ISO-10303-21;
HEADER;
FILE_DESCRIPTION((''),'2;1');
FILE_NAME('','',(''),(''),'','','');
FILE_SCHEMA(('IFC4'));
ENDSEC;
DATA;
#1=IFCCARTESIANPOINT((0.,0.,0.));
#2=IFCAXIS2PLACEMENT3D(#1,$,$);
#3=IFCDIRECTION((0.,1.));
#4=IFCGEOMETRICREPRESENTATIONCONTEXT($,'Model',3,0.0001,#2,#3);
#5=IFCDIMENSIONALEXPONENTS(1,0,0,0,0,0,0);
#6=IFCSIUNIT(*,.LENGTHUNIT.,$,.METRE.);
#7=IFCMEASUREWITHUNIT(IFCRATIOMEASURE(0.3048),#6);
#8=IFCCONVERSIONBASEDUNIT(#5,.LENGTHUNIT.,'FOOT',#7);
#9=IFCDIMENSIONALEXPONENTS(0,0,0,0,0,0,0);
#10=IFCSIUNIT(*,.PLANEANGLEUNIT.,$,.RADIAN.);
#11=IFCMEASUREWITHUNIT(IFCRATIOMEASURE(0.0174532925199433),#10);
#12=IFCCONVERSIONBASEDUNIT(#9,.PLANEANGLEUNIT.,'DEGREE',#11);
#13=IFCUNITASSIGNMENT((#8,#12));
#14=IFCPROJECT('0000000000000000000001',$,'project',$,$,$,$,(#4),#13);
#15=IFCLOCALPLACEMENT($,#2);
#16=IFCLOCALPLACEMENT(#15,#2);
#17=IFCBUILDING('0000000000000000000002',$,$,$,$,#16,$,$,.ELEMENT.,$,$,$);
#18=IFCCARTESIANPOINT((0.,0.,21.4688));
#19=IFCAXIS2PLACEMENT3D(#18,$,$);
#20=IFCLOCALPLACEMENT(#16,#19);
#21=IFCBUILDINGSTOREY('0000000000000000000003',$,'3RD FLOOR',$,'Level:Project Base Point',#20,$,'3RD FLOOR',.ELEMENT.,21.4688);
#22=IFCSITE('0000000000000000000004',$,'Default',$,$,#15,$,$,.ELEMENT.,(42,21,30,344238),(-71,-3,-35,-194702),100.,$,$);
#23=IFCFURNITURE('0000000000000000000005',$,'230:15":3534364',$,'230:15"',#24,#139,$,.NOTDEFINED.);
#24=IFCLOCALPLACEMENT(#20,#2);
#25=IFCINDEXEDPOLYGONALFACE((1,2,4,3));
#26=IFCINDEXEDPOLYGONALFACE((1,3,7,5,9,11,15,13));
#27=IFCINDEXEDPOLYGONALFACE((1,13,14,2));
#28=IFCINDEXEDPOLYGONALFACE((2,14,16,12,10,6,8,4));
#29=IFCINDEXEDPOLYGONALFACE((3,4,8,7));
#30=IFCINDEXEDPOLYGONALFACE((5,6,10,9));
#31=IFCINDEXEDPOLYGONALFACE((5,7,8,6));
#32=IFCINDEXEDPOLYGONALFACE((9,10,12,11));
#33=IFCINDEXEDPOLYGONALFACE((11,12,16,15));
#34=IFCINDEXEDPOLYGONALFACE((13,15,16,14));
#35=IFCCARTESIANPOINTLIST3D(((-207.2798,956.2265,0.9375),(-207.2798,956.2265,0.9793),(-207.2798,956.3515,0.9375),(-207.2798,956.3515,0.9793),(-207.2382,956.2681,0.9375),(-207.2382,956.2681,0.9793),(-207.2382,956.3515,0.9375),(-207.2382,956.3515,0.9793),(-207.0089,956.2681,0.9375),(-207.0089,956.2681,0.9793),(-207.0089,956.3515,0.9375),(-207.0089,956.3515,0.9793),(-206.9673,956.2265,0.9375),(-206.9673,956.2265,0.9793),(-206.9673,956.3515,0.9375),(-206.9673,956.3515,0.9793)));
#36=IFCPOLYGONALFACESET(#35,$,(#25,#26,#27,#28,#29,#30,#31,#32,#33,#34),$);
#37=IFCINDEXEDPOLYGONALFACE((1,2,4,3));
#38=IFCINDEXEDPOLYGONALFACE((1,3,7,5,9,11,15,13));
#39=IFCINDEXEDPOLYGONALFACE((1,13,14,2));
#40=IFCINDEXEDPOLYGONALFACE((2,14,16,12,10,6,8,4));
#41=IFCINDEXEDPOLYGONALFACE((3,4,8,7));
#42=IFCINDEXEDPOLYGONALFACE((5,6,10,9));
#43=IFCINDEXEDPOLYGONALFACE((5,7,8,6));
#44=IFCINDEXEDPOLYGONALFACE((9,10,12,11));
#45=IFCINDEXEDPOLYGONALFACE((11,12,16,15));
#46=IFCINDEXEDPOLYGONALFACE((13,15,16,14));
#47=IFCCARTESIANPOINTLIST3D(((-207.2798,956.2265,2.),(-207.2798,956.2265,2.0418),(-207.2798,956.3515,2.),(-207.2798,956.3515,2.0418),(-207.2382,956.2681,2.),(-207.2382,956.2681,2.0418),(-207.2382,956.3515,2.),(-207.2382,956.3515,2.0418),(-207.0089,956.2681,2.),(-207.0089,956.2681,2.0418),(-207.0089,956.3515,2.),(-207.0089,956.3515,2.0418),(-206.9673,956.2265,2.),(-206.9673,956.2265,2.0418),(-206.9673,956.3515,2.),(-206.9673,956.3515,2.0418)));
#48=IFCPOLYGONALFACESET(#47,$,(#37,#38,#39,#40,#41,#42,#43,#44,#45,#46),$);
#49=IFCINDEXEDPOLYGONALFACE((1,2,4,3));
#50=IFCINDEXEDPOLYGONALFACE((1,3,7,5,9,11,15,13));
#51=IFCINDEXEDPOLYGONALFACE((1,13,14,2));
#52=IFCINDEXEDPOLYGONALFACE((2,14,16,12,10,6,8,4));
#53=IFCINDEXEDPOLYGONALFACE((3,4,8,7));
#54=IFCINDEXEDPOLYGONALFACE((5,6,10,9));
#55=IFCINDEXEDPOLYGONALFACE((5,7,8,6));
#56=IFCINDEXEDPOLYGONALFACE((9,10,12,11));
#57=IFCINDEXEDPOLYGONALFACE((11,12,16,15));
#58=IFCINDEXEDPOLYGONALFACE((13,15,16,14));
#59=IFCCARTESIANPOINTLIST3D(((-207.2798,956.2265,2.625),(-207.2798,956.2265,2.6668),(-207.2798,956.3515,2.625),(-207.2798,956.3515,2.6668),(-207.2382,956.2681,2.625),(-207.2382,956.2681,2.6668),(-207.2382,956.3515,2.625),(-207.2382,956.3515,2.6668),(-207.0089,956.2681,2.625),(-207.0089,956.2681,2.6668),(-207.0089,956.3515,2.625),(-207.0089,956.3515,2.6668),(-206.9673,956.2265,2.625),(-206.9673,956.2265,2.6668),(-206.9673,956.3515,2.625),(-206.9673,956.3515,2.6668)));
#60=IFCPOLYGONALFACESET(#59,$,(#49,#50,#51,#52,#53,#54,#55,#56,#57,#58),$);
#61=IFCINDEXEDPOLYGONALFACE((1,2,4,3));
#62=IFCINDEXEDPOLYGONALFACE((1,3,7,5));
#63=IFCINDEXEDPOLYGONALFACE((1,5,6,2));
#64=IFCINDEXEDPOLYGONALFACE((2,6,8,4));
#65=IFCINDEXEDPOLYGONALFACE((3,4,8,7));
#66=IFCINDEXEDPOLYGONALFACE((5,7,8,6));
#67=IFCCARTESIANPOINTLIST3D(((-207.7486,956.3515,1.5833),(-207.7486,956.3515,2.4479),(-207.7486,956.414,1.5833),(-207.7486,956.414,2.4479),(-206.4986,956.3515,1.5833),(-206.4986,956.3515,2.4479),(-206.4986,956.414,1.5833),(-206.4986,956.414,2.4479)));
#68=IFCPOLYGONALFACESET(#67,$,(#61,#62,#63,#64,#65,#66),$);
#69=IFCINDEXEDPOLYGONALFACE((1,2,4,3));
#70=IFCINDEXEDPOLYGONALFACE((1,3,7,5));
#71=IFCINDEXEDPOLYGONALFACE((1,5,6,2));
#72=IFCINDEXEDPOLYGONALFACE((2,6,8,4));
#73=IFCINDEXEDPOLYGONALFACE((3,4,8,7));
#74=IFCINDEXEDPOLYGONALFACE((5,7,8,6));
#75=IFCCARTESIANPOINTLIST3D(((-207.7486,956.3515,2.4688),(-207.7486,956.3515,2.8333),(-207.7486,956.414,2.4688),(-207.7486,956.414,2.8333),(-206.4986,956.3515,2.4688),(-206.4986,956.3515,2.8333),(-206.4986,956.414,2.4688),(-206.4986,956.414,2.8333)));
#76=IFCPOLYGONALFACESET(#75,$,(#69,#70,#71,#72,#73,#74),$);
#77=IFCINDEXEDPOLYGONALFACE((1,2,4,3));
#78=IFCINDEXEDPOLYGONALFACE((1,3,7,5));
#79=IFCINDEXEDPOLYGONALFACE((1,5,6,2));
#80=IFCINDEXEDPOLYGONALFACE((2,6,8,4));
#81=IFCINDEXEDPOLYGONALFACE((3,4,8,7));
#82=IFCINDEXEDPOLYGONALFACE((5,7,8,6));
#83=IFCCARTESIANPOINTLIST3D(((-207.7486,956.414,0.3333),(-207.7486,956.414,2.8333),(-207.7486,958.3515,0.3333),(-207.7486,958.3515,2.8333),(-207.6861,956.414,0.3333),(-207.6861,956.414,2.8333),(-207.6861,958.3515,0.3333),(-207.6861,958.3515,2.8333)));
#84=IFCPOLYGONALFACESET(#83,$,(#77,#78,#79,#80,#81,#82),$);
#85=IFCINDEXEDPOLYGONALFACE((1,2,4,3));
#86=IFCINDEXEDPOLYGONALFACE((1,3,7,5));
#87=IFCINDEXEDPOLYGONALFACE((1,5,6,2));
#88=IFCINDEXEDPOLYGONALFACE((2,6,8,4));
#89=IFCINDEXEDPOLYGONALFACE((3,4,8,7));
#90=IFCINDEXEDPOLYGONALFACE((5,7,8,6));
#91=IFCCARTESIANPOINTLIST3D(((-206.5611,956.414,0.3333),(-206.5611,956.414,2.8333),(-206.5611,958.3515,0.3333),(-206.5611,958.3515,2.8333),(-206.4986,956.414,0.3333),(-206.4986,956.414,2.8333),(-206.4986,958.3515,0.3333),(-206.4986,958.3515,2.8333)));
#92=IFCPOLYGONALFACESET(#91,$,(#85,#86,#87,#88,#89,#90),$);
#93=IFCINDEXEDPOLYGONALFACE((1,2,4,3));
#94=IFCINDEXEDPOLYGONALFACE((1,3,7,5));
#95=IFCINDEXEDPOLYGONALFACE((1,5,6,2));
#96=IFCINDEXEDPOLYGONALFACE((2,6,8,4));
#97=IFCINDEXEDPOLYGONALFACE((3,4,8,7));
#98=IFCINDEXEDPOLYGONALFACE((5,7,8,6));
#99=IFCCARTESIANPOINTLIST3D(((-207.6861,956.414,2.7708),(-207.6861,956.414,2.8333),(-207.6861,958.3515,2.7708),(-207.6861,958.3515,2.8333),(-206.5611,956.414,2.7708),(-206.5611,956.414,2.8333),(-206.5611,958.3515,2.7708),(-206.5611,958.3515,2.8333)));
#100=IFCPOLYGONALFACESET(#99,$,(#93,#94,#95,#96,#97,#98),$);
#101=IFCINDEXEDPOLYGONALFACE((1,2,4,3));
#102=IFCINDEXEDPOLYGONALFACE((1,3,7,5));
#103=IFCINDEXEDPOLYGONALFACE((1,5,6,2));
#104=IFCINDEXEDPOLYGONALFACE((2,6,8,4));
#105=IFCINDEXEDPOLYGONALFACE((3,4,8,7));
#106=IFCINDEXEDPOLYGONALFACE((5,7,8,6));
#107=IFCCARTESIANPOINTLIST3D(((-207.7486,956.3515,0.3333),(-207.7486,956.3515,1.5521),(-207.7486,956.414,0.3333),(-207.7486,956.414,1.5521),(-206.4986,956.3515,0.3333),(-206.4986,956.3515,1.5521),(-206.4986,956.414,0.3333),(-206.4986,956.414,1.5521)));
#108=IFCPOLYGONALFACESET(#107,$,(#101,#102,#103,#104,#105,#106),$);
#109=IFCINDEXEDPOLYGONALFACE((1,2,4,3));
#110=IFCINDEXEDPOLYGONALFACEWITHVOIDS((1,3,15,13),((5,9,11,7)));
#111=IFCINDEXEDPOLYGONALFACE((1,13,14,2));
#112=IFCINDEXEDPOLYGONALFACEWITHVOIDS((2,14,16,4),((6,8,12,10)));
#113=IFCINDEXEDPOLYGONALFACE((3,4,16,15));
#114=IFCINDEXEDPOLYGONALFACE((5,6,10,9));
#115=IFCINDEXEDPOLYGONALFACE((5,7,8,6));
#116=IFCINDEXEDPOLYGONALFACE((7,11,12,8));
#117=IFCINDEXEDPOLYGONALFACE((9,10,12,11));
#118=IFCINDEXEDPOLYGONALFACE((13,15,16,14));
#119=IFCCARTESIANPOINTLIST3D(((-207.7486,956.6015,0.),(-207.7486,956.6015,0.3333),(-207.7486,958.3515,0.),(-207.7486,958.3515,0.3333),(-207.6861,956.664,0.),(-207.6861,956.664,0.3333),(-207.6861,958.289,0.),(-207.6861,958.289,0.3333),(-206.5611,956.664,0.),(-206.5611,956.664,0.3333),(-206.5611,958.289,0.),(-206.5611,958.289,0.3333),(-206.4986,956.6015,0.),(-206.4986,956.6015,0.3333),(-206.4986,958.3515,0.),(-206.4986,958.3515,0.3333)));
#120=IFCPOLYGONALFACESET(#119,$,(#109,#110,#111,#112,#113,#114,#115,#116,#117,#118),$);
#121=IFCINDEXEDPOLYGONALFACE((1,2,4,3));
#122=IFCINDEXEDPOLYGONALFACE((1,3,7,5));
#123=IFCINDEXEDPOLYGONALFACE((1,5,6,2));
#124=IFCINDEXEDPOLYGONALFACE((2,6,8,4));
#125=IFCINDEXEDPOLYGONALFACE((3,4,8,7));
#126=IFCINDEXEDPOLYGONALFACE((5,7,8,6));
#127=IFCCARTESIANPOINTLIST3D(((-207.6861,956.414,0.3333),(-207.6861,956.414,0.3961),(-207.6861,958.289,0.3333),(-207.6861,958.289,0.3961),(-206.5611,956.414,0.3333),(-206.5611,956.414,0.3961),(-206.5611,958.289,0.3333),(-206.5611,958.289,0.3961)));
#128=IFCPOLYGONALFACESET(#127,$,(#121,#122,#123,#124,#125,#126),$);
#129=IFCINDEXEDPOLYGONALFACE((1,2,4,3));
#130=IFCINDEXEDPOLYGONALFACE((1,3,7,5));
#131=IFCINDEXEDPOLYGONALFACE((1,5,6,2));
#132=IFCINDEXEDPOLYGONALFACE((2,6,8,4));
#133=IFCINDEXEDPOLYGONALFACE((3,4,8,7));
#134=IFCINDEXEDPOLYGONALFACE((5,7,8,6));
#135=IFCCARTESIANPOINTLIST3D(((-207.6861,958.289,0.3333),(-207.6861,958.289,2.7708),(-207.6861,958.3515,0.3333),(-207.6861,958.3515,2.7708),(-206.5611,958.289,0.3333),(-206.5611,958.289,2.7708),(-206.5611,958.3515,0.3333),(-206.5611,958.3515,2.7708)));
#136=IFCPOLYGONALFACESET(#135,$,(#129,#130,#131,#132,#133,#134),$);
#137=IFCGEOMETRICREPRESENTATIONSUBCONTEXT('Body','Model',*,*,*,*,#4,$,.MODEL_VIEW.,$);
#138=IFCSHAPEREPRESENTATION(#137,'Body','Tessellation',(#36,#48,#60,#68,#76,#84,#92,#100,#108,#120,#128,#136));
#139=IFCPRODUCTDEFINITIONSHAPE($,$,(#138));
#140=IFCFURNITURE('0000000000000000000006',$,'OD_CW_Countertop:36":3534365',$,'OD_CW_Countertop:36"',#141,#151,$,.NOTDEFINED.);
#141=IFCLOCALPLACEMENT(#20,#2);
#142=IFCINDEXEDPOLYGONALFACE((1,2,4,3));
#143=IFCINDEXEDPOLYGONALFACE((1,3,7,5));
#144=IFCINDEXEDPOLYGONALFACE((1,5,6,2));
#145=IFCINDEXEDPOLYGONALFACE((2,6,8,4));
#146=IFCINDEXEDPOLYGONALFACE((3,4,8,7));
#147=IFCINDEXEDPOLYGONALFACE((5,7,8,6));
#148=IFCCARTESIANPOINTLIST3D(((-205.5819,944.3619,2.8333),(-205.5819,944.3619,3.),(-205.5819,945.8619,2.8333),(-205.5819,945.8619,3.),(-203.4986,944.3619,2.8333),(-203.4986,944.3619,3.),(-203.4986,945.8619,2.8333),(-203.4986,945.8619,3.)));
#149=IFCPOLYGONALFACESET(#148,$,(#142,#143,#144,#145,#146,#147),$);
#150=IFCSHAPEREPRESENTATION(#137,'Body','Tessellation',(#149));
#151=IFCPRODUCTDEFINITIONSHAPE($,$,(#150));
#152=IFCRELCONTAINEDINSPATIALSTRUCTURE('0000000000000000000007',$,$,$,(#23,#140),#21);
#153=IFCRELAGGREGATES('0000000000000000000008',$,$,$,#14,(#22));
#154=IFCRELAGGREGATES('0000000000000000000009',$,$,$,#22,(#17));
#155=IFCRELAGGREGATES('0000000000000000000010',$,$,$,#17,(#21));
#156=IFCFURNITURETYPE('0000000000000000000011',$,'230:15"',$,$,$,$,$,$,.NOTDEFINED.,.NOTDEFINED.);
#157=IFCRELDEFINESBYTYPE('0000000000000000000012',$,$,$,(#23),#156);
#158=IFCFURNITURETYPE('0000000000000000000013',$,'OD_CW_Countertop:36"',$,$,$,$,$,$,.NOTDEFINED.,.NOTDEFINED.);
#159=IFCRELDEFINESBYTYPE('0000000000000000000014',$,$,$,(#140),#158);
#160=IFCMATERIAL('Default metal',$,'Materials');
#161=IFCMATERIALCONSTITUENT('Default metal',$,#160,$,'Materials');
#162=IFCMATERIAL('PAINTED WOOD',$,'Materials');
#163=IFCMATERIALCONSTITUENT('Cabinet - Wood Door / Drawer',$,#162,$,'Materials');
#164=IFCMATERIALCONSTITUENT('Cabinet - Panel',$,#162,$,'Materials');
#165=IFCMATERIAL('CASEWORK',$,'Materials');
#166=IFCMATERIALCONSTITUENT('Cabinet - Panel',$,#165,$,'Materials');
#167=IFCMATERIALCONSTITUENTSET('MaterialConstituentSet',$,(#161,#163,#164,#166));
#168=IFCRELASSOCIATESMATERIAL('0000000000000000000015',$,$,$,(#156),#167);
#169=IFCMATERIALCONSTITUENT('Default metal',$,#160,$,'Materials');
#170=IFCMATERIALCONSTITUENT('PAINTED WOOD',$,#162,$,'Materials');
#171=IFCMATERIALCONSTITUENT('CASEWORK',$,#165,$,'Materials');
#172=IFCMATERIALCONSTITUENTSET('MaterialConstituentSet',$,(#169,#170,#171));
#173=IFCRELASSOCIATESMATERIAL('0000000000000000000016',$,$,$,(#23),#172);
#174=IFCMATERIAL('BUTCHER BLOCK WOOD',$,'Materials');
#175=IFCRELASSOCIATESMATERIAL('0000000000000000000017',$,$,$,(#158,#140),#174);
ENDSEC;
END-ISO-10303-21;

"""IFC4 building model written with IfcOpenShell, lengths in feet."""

from ifc_helpers import new_model, entity, si_unit, converted_unit, direction, frame, frame_2d, origin, origin_2d_with_axis, place, context, subcontext, project, spatial, polyline, rectangle, outline, extrude, source, transform, mapped, material, constituent, constituent_set, type_object, type_shapes, element, save


model = new_model("IFC4")

# Units and contexts
model_context = context("Model", 3, precision=0.0001, world=origin(), true_north=direction((0.0, 1.0)))
body_context = subcontext(model_context, "Body", "Model", "MODEL_VIEW")
ifc_project = project(units=[converted_unit("LENGTHUNIT", "FOOT", entity("IfcRatioMeasure", 0.3048), si_unit("LENGTHUNIT", "METRE"), dimensions=[1, 0, 0, 0, 0, 0, 0]), converted_unit("PLANEANGLEUNIT", "DEGREE", entity("IfcRatioMeasure", 0.0174532925199433), si_unit("PLANEANGLEUNIT", "RADIAN"), dimensions=[0, 0, 0, 0, 0, 0, 0])], contexts=[model_context])

# Site, building, storey
site_placement = place(None, origin())
site = spatial("IfcSite", under=ifc_project, at=site_placement, Name="Default", CompositionType="ELEMENT", RefLatitude=(42, 21, 30, 344238), RefLongitude=(-71, -3, -35, -194702), RefElevation=100.0)
building_placement = place(site_placement, origin())
building = spatial("IfcBuilding", under=site, at=building_placement, CompositionType="ELEMENT")
storey_placement = place(building_placement, frame((0.0, 0.0, 21.4688)))
storey = spatial("IfcBuildingStorey", under=building, at=storey_placement, Name="3RD FLOOR", ObjectType="Level:Project Base Point", LongName="3RD FLOOR", CompositionType="ELEMENT", Elevation=21.4688)

# Furniture
ifc_material_1 = material(Name="CASEWORK", Category="Materials")
ifc_material_2 = material(Name="PAINTED WOOD", Category="Materials")
ifc_material_3 = material(Name="Default metal", Category="Materials")
ifc_material_4 = material(Name="BUTCHER BLOCK WOOD", Category="Materials")
ifc_constituent_1 = constituent(ifc_material_3, Name="Default metal", Category="Materials")
ifc_constituent_2 = constituent(ifc_material_2, Name="PAINTED WOOD", Category="Materials")
ifc_constituent_3 = constituent(ifc_material_1, Name="CASEWORK", Category="Materials")
ifc_constituent_set_1 = constituent_set(constituents=[ifc_constituent_1, ifc_constituent_2, ifc_constituent_3], Name="MaterialConstituentSet")
ifc_constituent_4 = constituent(ifc_material_3, Name="Default metal", Category="Materials")
ifc_constituent_5 = constituent(ifc_material_2, Name="Cabinet - Wood Door / Drawer", Category="Materials")
ifc_constituent_6 = constituent(ifc_material_2, Name="Cabinet - Panel", Category="Materials")
ifc_constituent_7 = constituent(ifc_material_1, Name="Cabinet - Panel", Category="Materials")
ifc_constituent_set_2 = constituent_set(constituents=[ifc_constituent_4, ifc_constituent_5, ifc_constituent_6, ifc_constituent_7], Name="MaterialConstituentSet")
furniture_type_1 = type_object("IfcFurnitureType", Name="230:15\"", AssemblyPlace="NOTDEFINED", PredefinedType="NOTDEFINED", material=ifc_constituent_set_2)
shared_shape_1 = source(origin(), body_context, "Body", "SweptSolid", [
    extrude(outline(polyline([(-0.0521, -0.1562), (0.0729, -0.1562), (0.0729, 0.1562), (-0.0521, 0.1562), (-0.0521, 0.1146), (0.0313, 0.1146), (0.0313, -0.1146), (-0.0521, -0.1146), (-0.0521, -0.1562)])), frame((0.0615, -2.0521, 0.9375), z_axis=(0.0, 0.0, 1.0), x_axis=(0.0, -1.0, 0.0)), (0.0, 0.0, 1.0), 0.0418),
    extrude(outline(polyline([(-0.0521, -0.1562), (0.0729, -0.1562), (0.0729, 0.1562), (-0.0521, 0.1562), (-0.0521, 0.1146), (0.0313, 0.1146), (0.0313, -0.1146), (-0.0521, -0.1146), (-0.0521, -0.1562)])), frame((0.0615, -2.0521, 2.0), z_axis=(0.0, 0.0, 1.0), x_axis=(0.0, -1.0, 0.0)), (0.0, 0.0, 1.0), 0.0418),
    extrude(outline(polyline([(-0.0521, -0.1562), (0.0729, -0.1562), (0.0729, 0.1562), (-0.0521, 0.1562), (-0.0521, 0.1146), (0.0313, 0.1146), (0.0313, -0.1146), (-0.0521, -0.1146), (-0.0521, -0.1562)])), frame((0.0615, -2.0521, 2.625), z_axis=(0.0, 0.0, 1.0), x_axis=(0.0, -1.0, 0.0)), (0.0, 0.0, 1.0), 0.0418),
    extrude(rectangle(XDim=0.0625, YDim=1.25, at=frame_2d((0.0, 0.0), x_axis=(1.0, 0.0))), frame((0.0615, -1.9688, 1.5833), z_axis=(0.0, 0.0, 1.0), x_axis=(0.0, 1.0, 0.0)), (0.0, 0.0, 1.0), 0.8646),
    extrude(rectangle(XDim=0.0625, YDim=1.25, at=frame_2d((0.0, 0.0), x_axis=(1.0, 0.0))), frame((0.0615, -1.9688, 2.4688), z_axis=(0.0, 0.0, 1.0), x_axis=(0.0, 1.0, 0.0)), (0.0, 0.0, 1.0), 0.3646),
    extrude(rectangle(XDim=0.0625, YDim=1.9375, at=frame_2d((0.0, 0.0), x_axis=(1.0, 0.0))), frame((-0.5323, -0.9687, 0.3333)), (0.0, 0.0, 1.0), 2.5),
    extrude(rectangle(XDim=0.0625, YDim=1.9375, at=frame_2d((0.0, 0.0), x_axis=(1.0, 0.0))), frame((0.6552, -0.9687, 0.3333)), (0.0, 0.0, 1.0), 2.5),
    extrude(rectangle(XDim=1.125, YDim=1.9375, at=origin_2d_with_axis()), frame((0.0615, -0.9687, 2.7708), z_axis=(0.0, 0.0, 1.0), x_axis=(-1.0, 0.0, 0.0)), (0.0, 0.0, 1.0), 0.0625),
    extrude(rectangle(XDim=0.0625, YDim=1.25, at=frame_2d((0.0, 0.0), x_axis=(1.0, 0.0))), frame((0.0615, -1.9688, 0.3333), z_axis=(0.0, 0.0, 1.0), x_axis=(0.0, 1.0, 0.0)), (0.0, 0.0, 1.0), 1.2187),
    extrude(outline(polyline([(-0.625, -0.875), (0.625, -0.875), (0.625, 0.875), (-0.625, 0.875), (-0.625, -0.875)]), holes=[polyline([(-0.5625, -0.8125), (-0.5625, 0.8125), (0.5625, 0.8125), (0.5625, -0.8125), (-0.5625, -0.8125)])]), frame((0.0615, -0.875, 0.0)), (0.0, 0.0, 1.0), 0.3333),
    extrude(rectangle(XDim=1.125, YDim=1.875, at=frame_2d((0.0, 0.0), x_axis=(1.0, 0.0))), frame((0.0615, -1.0, 0.3333), z_axis=(0.0, 0.0, 1.0), x_axis=(-1.0, 0.0, 0.0)), (0.0, 0.0, 1.0), 0.0627),
    extrude(rectangle(XDim=0.0625, YDim=1.125, at=origin_2d_with_axis()), frame((0.0615, -0.0312, 0.3333), z_axis=(0.0, 0.0, 1.0), x_axis=(0.0, 1.0, 0.0)), (0.0, 0.0, 1.0), 2.4375),
])
type_shapes(furniture_type_1, [shared_shape_1])
furniture_1_placement = place(storey_placement, frame((-207.1851, 958.3515, 0.0)))
element("IfcFurniture", 1, at=furniture_1_placement, inside=storey, type_object=furniture_type_1, material=ifc_constituent_set_1, Name="230:15\":3534364", ObjectType="230:15\"", PredefinedType="NOTDEFINED", context=body_context, shape_type="MappedRepresentation", body=[
    mapped(shared_shape_1, transform((0.0, 0.0, 0.0), scale=1.0)),
])
furniture_type_2 = type_object("IfcFurnitureType", Name="OD_CW_Countertop:36\"", AssemblyPlace="NOTDEFINED", PredefinedType="NOTDEFINED", material=ifc_material_4)
shared_shape_2 = source(origin(), body_context, "Body", "SweptSolid", [
    extrude(rectangle(XDim=1.5, YDim=2.0833, at=origin_2d_with_axis()), frame((0.75, 1.0417, 0.0)), (0.0, 0.0, 1.0), 0.1667),
])
type_shapes(furniture_type_2, [shared_shape_2])
furniture_2_placement = place(storey_placement, frame((-203.4986, 944.3619, 2.8333), z_axis=(0.0, 0.0, 1.0), x_axis=(0.0, 1.0, 0.0)))
element("IfcFurniture", 2, at=furniture_2_placement, inside=storey, type_object=furniture_type_2, material=ifc_material_4, Name="OD_CW_Countertop:36\":3534365", ObjectType="OD_CW_Countertop:36\"", PredefinedType="NOTDEFINED", context=body_context, shape_type="MappedRepresentation", body=[
    mapped(shared_shape_2, transform((0.0, 0.0, 0.0), scale=1.0)),
])

save(model, "model.ifc")
